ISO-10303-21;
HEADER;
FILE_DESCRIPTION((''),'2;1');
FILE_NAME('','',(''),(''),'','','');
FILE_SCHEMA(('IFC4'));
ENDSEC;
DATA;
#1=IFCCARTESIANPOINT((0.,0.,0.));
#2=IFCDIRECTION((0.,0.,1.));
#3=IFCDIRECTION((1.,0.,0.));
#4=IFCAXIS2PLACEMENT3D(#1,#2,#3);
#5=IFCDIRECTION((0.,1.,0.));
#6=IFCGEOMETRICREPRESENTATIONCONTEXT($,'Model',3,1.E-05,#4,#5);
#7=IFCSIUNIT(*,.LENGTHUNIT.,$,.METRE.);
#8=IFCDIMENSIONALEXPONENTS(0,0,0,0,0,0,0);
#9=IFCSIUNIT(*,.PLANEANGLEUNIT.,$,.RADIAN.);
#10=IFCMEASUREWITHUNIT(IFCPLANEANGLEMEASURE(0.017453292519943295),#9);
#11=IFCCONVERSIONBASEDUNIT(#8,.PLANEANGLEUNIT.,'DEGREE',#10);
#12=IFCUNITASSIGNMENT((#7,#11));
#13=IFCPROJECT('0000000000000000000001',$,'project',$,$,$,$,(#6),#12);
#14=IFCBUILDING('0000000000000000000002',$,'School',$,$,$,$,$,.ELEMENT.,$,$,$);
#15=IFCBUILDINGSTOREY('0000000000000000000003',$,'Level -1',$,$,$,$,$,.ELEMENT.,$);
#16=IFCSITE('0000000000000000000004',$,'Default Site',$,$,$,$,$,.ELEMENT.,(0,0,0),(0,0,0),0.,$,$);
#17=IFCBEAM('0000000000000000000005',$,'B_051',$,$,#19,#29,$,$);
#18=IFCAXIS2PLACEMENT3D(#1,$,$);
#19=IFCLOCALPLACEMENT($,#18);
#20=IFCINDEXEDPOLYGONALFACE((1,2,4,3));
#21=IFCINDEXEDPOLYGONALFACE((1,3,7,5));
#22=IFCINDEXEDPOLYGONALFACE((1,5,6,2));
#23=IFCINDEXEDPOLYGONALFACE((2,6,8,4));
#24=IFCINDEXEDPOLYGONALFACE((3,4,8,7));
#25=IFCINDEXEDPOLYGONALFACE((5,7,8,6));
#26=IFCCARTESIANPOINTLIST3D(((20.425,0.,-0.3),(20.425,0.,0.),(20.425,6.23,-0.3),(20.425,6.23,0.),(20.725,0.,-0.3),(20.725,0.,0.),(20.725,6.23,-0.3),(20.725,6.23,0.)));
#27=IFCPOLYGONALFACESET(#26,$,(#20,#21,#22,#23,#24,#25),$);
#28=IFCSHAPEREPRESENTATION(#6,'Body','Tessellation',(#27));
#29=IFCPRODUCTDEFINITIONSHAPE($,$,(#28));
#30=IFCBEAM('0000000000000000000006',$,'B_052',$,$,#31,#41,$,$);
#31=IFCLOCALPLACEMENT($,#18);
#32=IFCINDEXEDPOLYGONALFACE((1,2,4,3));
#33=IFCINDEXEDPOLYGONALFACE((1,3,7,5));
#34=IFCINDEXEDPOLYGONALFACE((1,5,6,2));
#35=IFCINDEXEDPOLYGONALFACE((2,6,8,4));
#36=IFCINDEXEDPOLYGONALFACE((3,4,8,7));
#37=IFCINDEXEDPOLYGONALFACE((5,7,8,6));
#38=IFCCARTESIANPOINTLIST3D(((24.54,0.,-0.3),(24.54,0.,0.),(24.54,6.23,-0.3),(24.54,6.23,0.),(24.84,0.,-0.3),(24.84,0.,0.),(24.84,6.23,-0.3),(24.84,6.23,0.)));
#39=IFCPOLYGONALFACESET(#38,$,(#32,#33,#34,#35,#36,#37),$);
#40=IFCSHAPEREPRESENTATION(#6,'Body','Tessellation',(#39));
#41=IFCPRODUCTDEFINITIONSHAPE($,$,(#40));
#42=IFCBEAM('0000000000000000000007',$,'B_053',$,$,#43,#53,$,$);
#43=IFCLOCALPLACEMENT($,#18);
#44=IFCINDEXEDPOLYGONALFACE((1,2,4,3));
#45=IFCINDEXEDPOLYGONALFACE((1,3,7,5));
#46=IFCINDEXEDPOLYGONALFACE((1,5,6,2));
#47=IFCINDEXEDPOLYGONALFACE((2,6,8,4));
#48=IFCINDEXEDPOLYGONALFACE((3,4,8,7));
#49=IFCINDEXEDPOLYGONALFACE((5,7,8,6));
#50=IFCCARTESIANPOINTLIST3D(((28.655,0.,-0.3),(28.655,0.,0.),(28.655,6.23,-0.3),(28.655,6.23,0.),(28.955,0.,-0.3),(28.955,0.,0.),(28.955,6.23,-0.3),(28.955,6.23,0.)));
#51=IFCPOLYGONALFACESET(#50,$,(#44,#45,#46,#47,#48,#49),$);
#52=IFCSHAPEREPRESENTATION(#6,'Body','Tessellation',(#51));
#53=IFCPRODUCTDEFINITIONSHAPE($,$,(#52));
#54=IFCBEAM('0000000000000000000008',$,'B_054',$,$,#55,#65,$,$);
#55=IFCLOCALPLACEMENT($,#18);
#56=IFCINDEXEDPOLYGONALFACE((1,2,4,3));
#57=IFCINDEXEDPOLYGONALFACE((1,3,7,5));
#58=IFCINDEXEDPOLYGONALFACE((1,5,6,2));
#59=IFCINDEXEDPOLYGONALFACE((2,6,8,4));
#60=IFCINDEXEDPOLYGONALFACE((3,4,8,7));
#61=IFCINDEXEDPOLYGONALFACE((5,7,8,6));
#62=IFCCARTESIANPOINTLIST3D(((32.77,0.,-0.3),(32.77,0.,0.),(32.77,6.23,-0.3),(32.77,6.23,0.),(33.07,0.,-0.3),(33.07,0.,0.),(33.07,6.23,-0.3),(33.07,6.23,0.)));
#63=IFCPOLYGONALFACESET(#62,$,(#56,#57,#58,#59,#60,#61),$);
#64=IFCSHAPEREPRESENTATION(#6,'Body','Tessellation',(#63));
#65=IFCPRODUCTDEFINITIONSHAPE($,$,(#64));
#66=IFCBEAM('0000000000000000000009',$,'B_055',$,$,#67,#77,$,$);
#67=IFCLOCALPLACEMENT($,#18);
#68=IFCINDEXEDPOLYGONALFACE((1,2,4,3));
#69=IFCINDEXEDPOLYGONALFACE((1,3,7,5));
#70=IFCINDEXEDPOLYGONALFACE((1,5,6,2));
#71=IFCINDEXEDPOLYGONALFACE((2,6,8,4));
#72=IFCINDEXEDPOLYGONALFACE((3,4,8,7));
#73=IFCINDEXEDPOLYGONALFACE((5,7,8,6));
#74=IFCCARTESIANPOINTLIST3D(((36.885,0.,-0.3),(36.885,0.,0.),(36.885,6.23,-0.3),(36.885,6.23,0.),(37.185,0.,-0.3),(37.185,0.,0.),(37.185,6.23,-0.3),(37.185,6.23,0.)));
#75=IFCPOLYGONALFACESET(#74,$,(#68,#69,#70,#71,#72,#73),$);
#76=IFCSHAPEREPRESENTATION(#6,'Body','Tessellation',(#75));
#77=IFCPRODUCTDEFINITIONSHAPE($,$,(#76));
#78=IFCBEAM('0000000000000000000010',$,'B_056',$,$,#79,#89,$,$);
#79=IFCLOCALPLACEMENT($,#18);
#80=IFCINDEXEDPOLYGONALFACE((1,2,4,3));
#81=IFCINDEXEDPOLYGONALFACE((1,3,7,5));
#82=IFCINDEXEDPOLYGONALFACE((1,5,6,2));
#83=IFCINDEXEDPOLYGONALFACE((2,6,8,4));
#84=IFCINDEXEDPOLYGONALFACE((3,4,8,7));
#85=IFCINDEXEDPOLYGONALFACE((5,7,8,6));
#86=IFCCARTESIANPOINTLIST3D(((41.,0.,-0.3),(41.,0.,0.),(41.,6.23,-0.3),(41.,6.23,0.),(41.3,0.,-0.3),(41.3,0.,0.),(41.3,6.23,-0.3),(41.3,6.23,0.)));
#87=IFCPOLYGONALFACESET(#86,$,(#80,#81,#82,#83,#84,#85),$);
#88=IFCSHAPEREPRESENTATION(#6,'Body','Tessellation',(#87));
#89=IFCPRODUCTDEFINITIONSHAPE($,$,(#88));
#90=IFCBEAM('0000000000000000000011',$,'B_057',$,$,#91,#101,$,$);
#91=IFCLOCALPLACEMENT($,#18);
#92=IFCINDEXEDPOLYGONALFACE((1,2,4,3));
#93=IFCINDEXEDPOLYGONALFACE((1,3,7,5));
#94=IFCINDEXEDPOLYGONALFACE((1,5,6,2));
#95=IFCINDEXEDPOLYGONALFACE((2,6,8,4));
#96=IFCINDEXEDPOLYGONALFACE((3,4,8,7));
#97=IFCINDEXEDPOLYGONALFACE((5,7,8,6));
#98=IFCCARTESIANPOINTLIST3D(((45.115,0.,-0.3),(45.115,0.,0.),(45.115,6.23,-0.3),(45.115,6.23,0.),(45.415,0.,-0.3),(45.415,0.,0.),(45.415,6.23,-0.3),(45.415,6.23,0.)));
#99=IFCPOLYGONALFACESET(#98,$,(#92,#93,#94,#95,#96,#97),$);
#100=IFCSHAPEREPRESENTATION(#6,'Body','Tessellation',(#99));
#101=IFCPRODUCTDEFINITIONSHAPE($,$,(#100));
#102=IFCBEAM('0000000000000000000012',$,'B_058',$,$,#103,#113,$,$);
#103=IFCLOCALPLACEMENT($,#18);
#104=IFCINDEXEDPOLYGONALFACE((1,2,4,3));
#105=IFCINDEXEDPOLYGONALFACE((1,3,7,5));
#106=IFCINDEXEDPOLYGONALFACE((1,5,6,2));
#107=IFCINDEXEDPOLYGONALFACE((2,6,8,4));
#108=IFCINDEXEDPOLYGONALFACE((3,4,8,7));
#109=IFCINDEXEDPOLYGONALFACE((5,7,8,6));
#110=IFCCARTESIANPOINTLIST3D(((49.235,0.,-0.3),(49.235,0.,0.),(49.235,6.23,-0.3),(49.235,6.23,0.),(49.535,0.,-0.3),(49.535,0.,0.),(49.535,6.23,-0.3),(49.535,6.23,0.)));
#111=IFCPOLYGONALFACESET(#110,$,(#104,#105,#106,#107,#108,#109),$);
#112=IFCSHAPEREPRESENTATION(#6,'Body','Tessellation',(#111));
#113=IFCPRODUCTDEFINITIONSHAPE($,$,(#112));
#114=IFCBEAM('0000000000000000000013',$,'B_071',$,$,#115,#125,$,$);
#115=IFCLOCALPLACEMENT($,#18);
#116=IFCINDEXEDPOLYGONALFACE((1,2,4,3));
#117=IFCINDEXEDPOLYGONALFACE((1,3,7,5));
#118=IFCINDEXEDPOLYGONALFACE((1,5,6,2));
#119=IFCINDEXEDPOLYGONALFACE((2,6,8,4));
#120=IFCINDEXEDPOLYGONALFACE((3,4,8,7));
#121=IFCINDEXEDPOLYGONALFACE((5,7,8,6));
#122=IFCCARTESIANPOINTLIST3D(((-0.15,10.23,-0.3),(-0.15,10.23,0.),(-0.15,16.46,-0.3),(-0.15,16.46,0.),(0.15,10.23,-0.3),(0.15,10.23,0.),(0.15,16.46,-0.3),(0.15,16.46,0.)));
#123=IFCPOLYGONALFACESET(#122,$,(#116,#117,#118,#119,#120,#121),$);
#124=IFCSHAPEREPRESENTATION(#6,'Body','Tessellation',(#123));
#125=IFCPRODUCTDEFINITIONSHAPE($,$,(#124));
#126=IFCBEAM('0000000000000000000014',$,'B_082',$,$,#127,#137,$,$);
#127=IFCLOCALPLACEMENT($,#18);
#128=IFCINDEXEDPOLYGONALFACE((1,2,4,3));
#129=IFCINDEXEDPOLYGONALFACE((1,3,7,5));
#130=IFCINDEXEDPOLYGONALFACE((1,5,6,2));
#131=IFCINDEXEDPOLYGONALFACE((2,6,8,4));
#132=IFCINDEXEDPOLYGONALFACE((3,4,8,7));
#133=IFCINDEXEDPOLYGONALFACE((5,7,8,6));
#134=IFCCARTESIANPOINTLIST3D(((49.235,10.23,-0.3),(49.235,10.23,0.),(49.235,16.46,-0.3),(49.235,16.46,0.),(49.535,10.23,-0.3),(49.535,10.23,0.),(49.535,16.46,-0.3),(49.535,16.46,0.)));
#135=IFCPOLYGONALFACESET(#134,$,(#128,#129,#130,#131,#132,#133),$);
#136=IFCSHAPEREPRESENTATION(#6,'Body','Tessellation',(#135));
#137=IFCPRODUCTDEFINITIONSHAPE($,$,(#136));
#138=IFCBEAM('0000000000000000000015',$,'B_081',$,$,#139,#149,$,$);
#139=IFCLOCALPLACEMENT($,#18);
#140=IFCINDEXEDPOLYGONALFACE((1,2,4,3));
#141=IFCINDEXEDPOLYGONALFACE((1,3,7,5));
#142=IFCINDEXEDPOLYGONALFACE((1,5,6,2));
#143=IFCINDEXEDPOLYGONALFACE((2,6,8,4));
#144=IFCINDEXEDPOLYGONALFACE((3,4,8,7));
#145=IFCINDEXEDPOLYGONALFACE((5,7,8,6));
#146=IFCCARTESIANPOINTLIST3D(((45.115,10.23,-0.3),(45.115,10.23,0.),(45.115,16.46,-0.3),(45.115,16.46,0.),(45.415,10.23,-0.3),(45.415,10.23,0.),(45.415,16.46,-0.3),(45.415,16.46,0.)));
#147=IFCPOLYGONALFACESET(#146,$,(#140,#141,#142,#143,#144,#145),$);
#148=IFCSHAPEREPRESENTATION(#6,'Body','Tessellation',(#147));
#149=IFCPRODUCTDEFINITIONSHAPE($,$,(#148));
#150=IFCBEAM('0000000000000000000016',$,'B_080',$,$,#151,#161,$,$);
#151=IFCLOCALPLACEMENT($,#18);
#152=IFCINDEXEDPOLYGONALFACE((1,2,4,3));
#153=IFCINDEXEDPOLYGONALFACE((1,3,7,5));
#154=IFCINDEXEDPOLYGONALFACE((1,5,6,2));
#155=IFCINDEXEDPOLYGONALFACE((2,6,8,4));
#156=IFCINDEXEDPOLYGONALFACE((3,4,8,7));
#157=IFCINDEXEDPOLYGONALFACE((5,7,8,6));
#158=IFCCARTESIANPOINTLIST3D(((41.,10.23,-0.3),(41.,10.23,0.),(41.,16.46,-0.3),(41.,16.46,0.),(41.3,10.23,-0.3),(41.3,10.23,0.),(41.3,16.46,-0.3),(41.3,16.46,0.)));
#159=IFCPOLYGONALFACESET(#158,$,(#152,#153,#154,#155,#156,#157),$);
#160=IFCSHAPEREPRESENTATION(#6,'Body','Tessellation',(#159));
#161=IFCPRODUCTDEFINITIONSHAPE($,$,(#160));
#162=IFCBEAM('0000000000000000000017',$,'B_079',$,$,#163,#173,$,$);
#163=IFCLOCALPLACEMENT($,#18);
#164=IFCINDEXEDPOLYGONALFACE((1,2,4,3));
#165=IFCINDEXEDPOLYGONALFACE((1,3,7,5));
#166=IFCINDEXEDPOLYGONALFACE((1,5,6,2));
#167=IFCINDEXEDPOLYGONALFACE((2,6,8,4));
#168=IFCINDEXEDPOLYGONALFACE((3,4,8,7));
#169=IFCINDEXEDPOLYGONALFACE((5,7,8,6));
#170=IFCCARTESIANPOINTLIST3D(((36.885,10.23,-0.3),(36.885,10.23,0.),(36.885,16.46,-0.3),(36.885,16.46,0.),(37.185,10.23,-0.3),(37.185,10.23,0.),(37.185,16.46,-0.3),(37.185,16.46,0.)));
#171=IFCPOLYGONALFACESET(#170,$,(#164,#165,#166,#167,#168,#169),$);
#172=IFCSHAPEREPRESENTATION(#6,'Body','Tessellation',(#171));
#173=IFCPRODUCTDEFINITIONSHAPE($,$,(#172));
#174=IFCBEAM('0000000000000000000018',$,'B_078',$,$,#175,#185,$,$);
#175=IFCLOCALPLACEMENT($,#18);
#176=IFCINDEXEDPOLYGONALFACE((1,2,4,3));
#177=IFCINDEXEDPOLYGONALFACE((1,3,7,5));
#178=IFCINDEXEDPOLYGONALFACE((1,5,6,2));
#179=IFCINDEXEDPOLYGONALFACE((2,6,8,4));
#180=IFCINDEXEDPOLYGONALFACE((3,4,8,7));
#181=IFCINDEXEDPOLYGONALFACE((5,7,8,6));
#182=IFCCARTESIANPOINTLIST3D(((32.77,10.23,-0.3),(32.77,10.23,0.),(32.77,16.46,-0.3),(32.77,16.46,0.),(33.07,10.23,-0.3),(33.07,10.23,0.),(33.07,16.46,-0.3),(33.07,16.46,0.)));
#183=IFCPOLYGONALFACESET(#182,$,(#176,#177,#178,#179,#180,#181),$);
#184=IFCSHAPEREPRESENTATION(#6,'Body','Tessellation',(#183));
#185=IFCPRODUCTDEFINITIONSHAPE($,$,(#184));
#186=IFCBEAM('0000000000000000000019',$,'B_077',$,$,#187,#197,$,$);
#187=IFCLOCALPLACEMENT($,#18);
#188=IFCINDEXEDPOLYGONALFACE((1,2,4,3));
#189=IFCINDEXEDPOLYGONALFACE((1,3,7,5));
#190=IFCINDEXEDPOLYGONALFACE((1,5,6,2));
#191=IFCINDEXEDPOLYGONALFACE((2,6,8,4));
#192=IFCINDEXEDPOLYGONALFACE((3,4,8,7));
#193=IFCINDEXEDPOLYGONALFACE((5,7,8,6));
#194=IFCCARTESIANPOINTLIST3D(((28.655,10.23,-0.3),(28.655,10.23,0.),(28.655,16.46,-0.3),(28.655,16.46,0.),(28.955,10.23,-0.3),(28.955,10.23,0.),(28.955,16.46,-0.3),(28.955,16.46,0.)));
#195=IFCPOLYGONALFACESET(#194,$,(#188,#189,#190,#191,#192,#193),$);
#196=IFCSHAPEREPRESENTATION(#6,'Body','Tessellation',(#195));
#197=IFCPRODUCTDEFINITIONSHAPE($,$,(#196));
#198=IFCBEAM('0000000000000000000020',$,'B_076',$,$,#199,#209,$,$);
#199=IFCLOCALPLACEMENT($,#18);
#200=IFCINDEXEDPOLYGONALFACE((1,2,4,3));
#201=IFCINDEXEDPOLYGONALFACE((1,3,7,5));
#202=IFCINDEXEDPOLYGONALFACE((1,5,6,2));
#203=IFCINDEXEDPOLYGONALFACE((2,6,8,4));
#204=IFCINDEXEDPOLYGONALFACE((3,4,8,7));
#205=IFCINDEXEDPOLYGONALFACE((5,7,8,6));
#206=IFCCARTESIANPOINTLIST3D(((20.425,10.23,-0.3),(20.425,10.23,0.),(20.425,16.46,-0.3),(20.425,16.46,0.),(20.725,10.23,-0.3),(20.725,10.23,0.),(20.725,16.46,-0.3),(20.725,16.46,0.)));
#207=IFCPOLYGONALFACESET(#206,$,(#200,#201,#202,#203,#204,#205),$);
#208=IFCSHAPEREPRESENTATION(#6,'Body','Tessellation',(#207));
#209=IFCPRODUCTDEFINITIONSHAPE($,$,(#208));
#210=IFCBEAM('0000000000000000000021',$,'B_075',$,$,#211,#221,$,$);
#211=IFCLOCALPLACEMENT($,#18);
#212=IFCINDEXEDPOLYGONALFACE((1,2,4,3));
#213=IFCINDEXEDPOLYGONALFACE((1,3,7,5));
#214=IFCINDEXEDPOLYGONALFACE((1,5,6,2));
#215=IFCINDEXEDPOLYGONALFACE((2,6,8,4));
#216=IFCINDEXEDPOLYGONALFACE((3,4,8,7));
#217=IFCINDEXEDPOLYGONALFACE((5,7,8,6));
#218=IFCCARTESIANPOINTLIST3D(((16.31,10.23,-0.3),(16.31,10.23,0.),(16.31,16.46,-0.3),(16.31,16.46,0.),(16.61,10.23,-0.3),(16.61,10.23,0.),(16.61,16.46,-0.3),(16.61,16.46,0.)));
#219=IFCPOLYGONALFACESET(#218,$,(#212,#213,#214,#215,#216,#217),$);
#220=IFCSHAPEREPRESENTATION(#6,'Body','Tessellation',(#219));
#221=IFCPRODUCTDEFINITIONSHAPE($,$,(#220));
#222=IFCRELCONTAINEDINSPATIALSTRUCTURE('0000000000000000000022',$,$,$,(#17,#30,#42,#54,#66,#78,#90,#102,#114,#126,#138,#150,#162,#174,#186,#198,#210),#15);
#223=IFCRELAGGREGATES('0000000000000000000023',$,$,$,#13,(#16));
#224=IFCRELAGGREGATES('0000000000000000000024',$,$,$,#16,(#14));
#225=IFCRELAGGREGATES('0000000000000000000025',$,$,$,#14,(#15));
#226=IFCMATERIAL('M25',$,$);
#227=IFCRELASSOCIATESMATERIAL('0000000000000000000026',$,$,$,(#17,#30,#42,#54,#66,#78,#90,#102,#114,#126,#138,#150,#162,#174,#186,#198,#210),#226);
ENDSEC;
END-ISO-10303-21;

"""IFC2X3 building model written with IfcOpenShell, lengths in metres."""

from ifc_helpers import new_model, entity, si_unit, converted_unit, direction, frame, frame_2d, origin_with_axes, place, context, project, spatial, rectangle, extrude, material, element, save


model = new_model("IFC2X3")

# Units and contexts
model_context = context("Model", 3, precision=1e-05, world=origin_with_axes(), true_north=direction((0.0, 1.0, 0.0)))
ifc_project = project(units=[si_unit("LENGTHUNIT", "METRE"), converted_unit("PLANEANGLEUNIT", "DEGREE", entity("IfcPlaneAngleMeasure", 0.017453292519943295), si_unit("PLANEANGLEUNIT", "RADIAN"), dimensions=[0, 0, 0, 0, 0, 0, 0])], contexts=[model_context])

# Site, building, storey
site = spatial("IfcSite", under=ifc_project, Name="Default Site", CompositionType="ELEMENT", RefLatitude=(0, 0, 0), RefLongitude=(0, 0, 0), RefElevation=0.0)
building = spatial("IfcBuilding", under=site, Name="School", CompositionType="ELEMENT")
storey = spatial("IfcBuildingStorey", under=building, Name="Level -1", CompositionType="ELEMENT")

# Beams
ifc_material = material(Name="M25")
placement = place(None, origin_with_axes())
element("IfcBeam", 1, at=placement, inside=storey, material=ifc_material, Name="B_051", context=model_context, shape_type="SweptSolid", body=[
    extrude(rectangle(XDim=0.3, YDim=0.3, at=frame_2d((0.0, 0.0), x_axis=(0.0, 1.0, 0.0))), frame((20.575, 0.0, -0.15), z_axis=(0.0, 1.0, 0.0), x_axis=(0.0, 0.0, -1.0)), (0.0, 0.0, 1.0), 6.23),
])
element("IfcBeam", 2, at=placement, inside=storey, material=ifc_material, Name="B_052", context=model_context, shape_type="SweptSolid", body=[
    extrude(rectangle(XDim=0.3, YDim=0.3, at=frame_2d((0.0, 0.0), x_axis=(0.0, 1.0, 0.0))), frame((24.69, 0.0, -0.15), z_axis=(0.0, 1.0, 0.0), x_axis=(0.0, 0.0, -1.0)), (0.0, 0.0, 1.0), 6.23),
])
element("IfcBeam", 3, at=placement, inside=storey, material=ifc_material, Name="B_053", context=model_context, shape_type="SweptSolid", body=[
    extrude(rectangle(XDim=0.3, YDim=0.3, at=frame_2d((0.0, 0.0), x_axis=(0.0, 1.0, 0.0))), frame((28.805, 0.0, -0.15), z_axis=(0.0, 1.0, 0.0), x_axis=(0.0, 0.0, -1.0)), (0.0, 0.0, 1.0), 6.23),
])
element("IfcBeam", 4, at=placement, inside=storey, material=ifc_material, Name="B_054", context=model_context, shape_type="SweptSolid", body=[
    extrude(rectangle(XDim=0.3, YDim=0.3, at=frame_2d((0.0, 0.0), x_axis=(0.0, 1.0, 0.0))), frame((32.92, 0.0, -0.15), z_axis=(0.0, 1.0, 0.0), x_axis=(0.0, 0.0, -1.0)), (0.0, 0.0, 1.0), 6.23),
])
element("IfcBeam", 5, at=placement, inside=storey, material=ifc_material, Name="B_055", context=model_context, shape_type="SweptSolid", body=[
    extrude(rectangle(XDim=0.3, YDim=0.3, at=frame_2d((0.0, 0.0), x_axis=(0.0, 1.0, 0.0))), frame((37.035, 0.0, -0.15), z_axis=(0.0, 1.0, 0.0), x_axis=(0.0, 0.0, -1.0)), (0.0, 0.0, 1.0), 6.23),
])
element("IfcBeam", 6, at=placement, inside=storey, material=ifc_material, Name="B_056", context=model_context, shape_type="SweptSolid", body=[
    extrude(rectangle(XDim=0.3, YDim=0.3, at=frame_2d((0.0, 0.0), x_axis=(0.0, 1.0, 0.0))), frame((41.15, 0.0, -0.15), z_axis=(0.0, 1.0, 0.0), x_axis=(0.0, 0.0, -1.0)), (0.0, 0.0, 1.0), 6.23),
])
element("IfcBeam", 7, at=placement, inside=storey, material=ifc_material, Name="B_057", context=model_context, shape_type="SweptSolid", body=[
    extrude(rectangle(XDim=0.3, YDim=0.3, at=frame_2d((0.0, 0.0), x_axis=(0.0, 1.0, 0.0))), frame((45.265, 0.0, -0.15), z_axis=(0.0, 1.0, 0.0), x_axis=(0.0, 0.0, -1.0)), (0.0, 0.0, 1.0), 6.23),
])
element("IfcBeam", 8, at=placement, inside=storey, material=ifc_material, Name="B_058", context=model_context, shape_type="SweptSolid", body=[
    extrude(rectangle(XDim=0.3, YDim=0.3, at=frame_2d((0.0, 0.0), x_axis=(0.0, 1.0, 0.0))), frame((49.385, 0.0, -0.15), z_axis=(0.0, 1.0, 0.0), x_axis=(0.0, 0.0, -1.0)), (0.0, 0.0, 1.0), 6.23),
])
element("IfcBeam", 9, at=placement, inside=storey, material=ifc_material, Name="B_071", context=model_context, shape_type="SweptSolid", body=[
    extrude(rectangle(XDim=0.3, YDim=0.3, at=frame_2d((0.0, 0.0), x_axis=(0.0, 1.0, 0.0))), frame((0.0, 10.23, -0.15), z_axis=(0.0, 1.0, 0.0), x_axis=(0.0, 0.0, -1.0)), (0.0, 0.0, 1.0), 6.23),
])
element("IfcBeam", 10, at=placement, inside=storey, material=ifc_material, Name="B_082", context=model_context, shape_type="SweptSolid", body=[
    extrude(rectangle(XDim=0.3, YDim=0.3, at=frame_2d((0.0, 0.0), x_axis=(0.0, 1.0, 0.0))), frame((49.385, 10.23, -0.15), z_axis=(0.0, 1.0, 0.0), x_axis=(0.0, 0.0, -1.0)), (0.0, 0.0, 1.0), 6.23),
])
element("IfcBeam", 11, at=placement, inside=storey, material=ifc_material, Name="B_081", context=model_context, shape_type="SweptSolid", body=[
    extrude(rectangle(XDim=0.3, YDim=0.3, at=frame_2d((0.0, 0.0), x_axis=(0.0, 1.0, 0.0))), frame((45.265, 10.23, -0.15), z_axis=(0.0, 1.0, 0.0), x_axis=(0.0, 0.0, -1.0)), (0.0, 0.0, 1.0), 6.23),
])
element("IfcBeam", 12, at=placement, inside=storey, material=ifc_material, Name="B_080", context=model_context, shape_type="SweptSolid", body=[
    extrude(rectangle(XDim=0.3, YDim=0.3, at=frame_2d((0.0, 0.0), x_axis=(0.0, 1.0, 0.0))), frame((41.15, 10.23, -0.15), z_axis=(0.0, 1.0, 0.0), x_axis=(0.0, 0.0, -1.0)), (0.0, 0.0, 1.0), 6.23),
])
element("IfcBeam", 13, at=placement, inside=storey, material=ifc_material, Name="B_079", context=model_context, shape_type="SweptSolid", body=[
    extrude(rectangle(XDim=0.3, YDim=0.3, at=frame_2d((0.0, 0.0), x_axis=(0.0, 1.0, 0.0))), frame((37.035, 10.23, -0.15), z_axis=(0.0, 1.0, 0.0), x_axis=(0.0, 0.0, -1.0)), (0.0, 0.0, 1.0), 6.23),
])
element("IfcBeam", 14, at=placement, inside=storey, material=ifc_material, Name="B_078", context=model_context, shape_type="SweptSolid", body=[
    extrude(rectangle(XDim=0.3, YDim=0.3, at=frame_2d((0.0, 0.0), x_axis=(0.0, 1.0, 0.0))), frame((32.92, 10.23, -0.15), z_axis=(0.0, 1.0, 0.0), x_axis=(0.0, 0.0, -1.0)), (0.0, 0.0, 1.0), 6.23),
])
element("IfcBeam", 15, at=placement, inside=storey, material=ifc_material, Name="B_077", context=model_context, shape_type="SweptSolid", body=[
    extrude(rectangle(XDim=0.3, YDim=0.3, at=frame_2d((0.0, 0.0), x_axis=(0.0, 1.0, 0.0))), frame((28.805, 10.23, -0.15), z_axis=(0.0, 1.0, 0.0), x_axis=(0.0, 0.0, -1.0)), (0.0, 0.0, 1.0), 6.23),
])
element("IfcBeam", 16, at=placement, inside=storey, material=ifc_material, Name="B_076", context=model_context, shape_type="SweptSolid", body=[
    extrude(rectangle(XDim=0.3, YDim=0.3, at=frame_2d((0.0, 0.0), x_axis=(0.0, 1.0, 0.0))), frame((20.575, 10.23, -0.15), z_axis=(0.0, 1.0, 0.0), x_axis=(0.0, 0.0, -1.0)), (0.0, 0.0, 1.0), 6.23),
])
element("IfcBeam", 17, at=placement, inside=storey, material=ifc_material, Name="B_075", context=model_context, shape_type="SweptSolid", body=[
    extrude(rectangle(XDim=0.3, YDim=0.3, at=frame_2d((0.0, 0.0), x_axis=(0.0, 1.0, 0.0))), frame((16.46, 10.23, -0.15), z_axis=(0.0, 1.0, 0.0), x_axis=(0.0, 0.0, -1.0)), (0.0, 0.0, 1.0), 6.23),
])

save(model, "model.ifc")
